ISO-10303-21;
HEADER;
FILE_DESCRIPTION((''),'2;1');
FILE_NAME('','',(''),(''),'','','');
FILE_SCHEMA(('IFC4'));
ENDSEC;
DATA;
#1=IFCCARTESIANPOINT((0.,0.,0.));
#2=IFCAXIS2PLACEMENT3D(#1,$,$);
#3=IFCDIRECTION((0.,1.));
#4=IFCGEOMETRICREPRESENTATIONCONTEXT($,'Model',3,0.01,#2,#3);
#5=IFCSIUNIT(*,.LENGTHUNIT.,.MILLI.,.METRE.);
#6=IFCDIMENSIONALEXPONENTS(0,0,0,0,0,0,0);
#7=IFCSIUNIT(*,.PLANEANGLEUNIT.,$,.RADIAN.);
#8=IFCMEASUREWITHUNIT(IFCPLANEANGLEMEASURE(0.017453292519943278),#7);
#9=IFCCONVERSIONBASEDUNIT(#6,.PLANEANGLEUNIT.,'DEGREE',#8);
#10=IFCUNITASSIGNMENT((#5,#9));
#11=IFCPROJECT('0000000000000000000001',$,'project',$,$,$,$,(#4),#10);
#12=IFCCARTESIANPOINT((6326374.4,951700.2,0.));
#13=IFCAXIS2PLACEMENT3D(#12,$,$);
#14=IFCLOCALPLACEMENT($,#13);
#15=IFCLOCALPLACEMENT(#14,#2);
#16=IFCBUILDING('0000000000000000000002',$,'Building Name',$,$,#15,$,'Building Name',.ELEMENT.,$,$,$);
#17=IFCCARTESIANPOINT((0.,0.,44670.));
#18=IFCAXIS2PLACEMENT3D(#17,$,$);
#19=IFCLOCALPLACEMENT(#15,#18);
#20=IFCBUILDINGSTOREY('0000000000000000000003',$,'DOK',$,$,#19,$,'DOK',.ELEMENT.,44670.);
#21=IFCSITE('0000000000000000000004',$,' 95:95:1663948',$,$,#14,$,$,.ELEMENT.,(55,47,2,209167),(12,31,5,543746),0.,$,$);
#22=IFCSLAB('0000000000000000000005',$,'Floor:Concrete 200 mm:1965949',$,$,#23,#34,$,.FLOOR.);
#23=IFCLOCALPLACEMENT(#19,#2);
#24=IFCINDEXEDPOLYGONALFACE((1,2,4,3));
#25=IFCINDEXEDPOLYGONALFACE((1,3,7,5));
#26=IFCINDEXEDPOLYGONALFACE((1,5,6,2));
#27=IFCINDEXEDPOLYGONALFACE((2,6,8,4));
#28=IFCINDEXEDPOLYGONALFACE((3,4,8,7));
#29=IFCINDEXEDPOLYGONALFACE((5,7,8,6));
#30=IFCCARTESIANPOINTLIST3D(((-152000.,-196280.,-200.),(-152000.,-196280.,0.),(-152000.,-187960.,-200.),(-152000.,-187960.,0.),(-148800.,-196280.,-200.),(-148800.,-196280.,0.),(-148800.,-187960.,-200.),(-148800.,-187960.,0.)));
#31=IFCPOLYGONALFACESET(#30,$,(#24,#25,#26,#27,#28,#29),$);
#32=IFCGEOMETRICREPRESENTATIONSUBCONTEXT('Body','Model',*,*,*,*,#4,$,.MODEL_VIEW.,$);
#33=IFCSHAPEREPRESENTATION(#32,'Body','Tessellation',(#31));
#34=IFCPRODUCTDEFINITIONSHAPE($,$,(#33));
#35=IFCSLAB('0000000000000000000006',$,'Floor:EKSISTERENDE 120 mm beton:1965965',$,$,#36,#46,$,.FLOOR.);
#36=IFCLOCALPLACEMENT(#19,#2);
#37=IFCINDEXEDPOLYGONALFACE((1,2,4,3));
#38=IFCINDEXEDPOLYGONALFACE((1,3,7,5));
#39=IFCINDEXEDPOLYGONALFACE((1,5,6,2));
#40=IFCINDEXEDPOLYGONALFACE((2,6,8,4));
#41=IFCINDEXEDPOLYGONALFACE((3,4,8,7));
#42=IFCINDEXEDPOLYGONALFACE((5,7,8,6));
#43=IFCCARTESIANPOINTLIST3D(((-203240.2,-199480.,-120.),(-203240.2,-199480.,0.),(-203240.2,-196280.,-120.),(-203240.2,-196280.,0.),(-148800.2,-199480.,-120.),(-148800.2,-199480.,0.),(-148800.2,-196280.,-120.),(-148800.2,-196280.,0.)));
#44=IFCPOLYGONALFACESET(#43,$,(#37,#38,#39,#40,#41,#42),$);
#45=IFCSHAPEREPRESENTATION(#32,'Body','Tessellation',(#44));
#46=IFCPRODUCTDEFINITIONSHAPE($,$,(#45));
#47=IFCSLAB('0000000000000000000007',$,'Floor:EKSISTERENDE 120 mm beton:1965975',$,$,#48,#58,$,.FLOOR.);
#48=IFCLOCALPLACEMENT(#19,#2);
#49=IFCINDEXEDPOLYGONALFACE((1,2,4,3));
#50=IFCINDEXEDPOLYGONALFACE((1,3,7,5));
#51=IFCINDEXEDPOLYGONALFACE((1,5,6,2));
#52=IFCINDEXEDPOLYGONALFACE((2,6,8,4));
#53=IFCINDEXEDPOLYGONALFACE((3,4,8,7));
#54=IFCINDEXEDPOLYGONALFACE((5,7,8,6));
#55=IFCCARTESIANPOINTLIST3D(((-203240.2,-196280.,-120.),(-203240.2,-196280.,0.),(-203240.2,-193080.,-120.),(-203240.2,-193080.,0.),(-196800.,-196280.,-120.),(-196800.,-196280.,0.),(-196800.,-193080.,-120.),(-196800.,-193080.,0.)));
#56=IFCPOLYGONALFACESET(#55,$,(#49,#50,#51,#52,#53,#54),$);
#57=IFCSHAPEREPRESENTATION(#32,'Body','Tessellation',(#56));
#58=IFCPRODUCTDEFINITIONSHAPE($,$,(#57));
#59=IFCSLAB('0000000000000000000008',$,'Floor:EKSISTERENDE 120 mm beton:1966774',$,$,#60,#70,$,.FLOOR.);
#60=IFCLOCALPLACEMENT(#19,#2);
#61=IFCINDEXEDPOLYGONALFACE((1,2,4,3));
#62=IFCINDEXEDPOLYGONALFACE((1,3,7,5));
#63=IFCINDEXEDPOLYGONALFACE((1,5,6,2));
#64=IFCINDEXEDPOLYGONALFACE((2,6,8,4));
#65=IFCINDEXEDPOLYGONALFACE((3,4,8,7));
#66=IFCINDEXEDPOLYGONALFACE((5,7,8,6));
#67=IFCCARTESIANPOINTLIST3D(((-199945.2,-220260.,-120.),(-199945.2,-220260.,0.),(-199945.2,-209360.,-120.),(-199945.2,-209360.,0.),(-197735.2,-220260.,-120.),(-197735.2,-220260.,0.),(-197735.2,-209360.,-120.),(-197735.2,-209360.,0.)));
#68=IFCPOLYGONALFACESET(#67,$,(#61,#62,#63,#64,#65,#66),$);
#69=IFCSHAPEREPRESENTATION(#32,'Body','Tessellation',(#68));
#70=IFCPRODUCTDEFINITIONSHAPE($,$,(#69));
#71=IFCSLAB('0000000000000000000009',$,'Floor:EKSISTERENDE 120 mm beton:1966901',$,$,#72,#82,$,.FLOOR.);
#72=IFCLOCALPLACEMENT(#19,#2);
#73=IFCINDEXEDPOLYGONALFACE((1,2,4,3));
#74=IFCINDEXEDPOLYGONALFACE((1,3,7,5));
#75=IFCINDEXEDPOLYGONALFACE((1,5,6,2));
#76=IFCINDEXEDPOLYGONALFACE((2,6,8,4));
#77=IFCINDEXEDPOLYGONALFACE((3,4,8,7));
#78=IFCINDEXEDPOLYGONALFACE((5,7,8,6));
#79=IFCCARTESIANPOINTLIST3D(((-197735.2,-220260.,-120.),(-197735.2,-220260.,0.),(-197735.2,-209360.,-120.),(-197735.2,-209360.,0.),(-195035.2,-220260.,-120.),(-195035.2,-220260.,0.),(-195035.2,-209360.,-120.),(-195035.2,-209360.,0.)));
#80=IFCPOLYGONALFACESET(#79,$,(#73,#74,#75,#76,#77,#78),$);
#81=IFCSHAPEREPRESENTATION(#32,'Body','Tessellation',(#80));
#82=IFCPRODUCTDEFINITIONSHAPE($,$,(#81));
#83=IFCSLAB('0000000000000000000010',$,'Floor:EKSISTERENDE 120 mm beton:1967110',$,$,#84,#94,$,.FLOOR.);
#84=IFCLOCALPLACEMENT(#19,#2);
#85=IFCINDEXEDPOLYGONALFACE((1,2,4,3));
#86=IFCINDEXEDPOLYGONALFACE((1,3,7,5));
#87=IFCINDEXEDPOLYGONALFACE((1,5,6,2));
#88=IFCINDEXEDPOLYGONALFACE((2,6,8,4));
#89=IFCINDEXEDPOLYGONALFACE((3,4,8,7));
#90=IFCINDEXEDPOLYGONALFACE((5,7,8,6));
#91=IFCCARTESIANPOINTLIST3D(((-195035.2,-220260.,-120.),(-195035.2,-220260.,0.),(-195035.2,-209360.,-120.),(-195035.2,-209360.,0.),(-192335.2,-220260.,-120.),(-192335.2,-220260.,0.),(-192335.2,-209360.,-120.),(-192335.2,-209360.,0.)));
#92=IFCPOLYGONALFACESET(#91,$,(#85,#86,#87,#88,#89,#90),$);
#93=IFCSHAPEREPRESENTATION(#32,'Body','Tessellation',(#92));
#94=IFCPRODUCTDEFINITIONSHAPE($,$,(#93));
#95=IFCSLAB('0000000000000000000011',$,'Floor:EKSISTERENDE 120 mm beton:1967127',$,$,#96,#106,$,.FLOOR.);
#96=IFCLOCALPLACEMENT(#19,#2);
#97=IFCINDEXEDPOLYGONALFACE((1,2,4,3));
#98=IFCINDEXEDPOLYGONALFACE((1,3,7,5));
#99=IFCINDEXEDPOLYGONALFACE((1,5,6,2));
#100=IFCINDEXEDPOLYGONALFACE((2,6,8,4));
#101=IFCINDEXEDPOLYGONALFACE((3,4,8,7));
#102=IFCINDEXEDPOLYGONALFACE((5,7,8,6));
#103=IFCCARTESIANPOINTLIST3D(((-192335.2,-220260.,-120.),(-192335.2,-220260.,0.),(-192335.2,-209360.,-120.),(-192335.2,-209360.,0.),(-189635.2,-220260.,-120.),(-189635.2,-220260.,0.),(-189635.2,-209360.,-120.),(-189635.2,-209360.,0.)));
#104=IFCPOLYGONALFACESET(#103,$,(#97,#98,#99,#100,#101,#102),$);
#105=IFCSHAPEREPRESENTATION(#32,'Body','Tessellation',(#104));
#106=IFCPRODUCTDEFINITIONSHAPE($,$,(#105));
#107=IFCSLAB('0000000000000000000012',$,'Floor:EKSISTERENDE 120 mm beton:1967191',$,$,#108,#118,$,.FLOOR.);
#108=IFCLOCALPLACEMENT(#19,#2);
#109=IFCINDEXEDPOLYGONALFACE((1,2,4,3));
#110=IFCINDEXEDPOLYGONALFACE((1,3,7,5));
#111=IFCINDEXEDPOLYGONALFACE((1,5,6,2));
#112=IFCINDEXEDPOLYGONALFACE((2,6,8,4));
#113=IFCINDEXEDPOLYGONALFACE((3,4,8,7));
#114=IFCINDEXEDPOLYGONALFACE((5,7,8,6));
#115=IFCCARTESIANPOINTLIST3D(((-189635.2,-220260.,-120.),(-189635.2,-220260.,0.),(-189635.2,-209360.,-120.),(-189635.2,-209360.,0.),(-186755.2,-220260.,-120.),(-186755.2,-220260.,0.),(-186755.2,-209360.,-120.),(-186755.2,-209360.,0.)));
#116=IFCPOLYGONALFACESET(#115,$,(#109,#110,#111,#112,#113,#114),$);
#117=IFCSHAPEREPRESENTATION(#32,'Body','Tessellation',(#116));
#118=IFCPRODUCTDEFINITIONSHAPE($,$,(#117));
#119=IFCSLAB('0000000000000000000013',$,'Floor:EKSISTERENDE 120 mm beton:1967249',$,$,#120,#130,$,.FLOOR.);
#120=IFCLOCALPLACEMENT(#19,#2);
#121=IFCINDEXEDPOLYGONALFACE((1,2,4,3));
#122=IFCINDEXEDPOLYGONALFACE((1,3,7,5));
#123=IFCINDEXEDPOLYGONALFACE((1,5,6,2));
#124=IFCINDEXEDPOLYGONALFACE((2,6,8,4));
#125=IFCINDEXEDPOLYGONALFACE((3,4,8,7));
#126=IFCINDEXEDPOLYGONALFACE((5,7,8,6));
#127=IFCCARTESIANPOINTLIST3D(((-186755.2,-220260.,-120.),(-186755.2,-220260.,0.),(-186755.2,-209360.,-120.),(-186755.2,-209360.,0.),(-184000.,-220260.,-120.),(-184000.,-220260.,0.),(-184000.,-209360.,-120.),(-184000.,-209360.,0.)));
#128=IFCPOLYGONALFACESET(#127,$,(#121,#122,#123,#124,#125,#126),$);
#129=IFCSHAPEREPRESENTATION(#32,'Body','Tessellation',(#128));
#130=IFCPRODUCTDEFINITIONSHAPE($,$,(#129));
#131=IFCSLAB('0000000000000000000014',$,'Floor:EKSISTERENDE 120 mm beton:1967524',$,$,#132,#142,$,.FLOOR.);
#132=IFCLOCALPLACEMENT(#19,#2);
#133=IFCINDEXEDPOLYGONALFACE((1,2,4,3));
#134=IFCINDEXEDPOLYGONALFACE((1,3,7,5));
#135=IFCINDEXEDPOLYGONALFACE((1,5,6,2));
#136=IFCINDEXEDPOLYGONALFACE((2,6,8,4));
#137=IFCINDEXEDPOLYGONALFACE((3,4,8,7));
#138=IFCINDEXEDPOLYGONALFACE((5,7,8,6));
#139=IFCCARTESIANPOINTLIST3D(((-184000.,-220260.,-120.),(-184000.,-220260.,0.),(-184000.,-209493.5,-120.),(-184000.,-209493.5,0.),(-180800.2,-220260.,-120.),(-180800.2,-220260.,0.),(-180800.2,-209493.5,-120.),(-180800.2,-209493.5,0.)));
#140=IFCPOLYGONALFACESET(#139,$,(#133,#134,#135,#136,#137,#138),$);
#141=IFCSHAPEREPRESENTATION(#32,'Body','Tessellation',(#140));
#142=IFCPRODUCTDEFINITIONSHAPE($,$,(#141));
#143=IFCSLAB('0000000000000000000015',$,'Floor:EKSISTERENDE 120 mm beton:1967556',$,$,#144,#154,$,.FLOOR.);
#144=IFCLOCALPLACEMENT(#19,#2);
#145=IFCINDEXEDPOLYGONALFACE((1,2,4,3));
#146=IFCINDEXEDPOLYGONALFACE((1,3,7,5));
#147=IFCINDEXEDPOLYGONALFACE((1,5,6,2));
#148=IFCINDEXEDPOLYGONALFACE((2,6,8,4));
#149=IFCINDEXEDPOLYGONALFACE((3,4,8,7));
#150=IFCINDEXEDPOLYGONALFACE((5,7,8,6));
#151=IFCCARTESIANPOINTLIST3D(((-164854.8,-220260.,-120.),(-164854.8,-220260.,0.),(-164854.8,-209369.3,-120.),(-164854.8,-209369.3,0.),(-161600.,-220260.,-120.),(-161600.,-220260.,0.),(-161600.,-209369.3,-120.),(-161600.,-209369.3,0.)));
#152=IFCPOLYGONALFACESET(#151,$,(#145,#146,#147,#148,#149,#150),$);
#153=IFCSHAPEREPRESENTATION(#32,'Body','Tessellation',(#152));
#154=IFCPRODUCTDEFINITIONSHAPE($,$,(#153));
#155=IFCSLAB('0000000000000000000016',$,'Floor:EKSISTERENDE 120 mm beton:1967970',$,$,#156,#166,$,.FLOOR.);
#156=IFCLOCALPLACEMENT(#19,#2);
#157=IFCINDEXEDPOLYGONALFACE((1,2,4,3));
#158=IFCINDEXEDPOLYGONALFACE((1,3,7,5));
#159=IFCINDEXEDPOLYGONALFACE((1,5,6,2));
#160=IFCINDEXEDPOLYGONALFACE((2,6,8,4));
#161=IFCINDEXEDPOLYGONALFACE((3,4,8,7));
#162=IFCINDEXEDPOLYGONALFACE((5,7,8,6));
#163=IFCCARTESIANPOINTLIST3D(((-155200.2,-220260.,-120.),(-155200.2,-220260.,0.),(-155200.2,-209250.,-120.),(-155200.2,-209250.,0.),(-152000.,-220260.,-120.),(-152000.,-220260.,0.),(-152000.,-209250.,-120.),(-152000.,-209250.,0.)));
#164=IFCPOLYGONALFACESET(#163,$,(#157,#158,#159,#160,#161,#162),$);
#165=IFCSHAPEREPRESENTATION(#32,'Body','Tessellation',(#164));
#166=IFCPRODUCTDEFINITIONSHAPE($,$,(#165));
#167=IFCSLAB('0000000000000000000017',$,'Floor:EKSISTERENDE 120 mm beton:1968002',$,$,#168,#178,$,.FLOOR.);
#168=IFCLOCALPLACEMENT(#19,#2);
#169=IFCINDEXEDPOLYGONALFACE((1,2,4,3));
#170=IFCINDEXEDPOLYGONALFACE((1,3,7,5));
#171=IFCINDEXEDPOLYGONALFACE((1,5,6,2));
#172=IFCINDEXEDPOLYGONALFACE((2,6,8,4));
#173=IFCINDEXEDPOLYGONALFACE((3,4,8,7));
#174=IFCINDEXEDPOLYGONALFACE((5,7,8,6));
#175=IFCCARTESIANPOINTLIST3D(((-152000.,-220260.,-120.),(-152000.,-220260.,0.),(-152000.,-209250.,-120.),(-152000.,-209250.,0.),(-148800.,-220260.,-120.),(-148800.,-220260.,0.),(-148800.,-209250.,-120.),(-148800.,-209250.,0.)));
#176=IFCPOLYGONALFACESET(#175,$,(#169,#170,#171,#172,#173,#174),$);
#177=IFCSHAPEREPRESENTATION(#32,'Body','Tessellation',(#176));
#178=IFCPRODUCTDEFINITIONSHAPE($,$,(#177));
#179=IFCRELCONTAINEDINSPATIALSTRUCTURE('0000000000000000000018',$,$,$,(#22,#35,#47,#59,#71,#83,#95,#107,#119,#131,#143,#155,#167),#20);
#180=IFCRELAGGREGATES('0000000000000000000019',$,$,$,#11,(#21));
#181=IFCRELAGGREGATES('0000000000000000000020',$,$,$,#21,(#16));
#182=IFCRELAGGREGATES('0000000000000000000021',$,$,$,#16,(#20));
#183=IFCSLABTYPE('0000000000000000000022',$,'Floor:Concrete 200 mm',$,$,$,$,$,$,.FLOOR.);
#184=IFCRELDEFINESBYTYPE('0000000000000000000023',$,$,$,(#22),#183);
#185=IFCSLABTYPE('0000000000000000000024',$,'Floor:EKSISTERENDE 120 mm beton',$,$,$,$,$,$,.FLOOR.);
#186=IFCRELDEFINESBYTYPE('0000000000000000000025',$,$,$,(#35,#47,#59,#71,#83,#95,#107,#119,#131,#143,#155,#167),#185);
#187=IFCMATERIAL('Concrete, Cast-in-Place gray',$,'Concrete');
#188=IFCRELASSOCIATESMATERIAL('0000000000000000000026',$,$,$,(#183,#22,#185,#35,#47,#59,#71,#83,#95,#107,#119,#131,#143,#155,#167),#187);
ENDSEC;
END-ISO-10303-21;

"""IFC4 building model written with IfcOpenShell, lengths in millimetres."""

from ifc_helpers import new_model, entity, si_unit, converted_unit, direction, frame, origin, place, context, subcontext, project, spatial, indexed_curve, outline, extrude, material, type_object, element, save


model = new_model("IFC4")

# Units and contexts
model_context = context("Model", 3, precision=0.01, world=origin(), true_north=direction((0.0, 1.0)))
body_context = subcontext(model_context, "Body", "Model", "MODEL_VIEW")
ifc_project = project(units=[si_unit("LENGTHUNIT", "METRE", prefix="MILLI"), converted_unit("PLANEANGLEUNIT", "DEGREE", entity("IfcPlaneAngleMeasure", 0.017453292519943278), si_unit("PLANEANGLEUNIT", "RADIAN"), dimensions=[0, 0, 0, 0, 0, 0, 0])], contexts=[model_context])

# Site, building, storey
site_placement = place(None, frame((6326374.4, 951700.2, 0.0)))
site = spatial("IfcSite", under=ifc_project, at=site_placement, Name=" 95:95:1663948", CompositionType="ELEMENT", RefLatitude=(55, 47, 2, 209167), RefLongitude=(12, 31, 5, 543746), RefElevation=0.0)
building_placement = place(site_placement, origin())
building = spatial("IfcBuilding", under=site, at=building_placement, Name="Building Name", LongName="Building Name", CompositionType="ELEMENT")
storey_placement = place(building_placement, frame((0.0, 0.0, 44670.0)))
storey = spatial("IfcBuildingStorey", under=building, at=storey_placement, Name="DOK", LongName="DOK", CompositionType="ELEMENT", Elevation=44670.0)

# Slabs
ifc_material = material(Name="Concrete, Cast-in-Place gray", Category="Concrete")
slab_type_1 = type_object("IfcSlabType", Name="Floor:Concrete 200 mm", PredefinedType="FLOOR", material=ifc_material)
slab_1_placement = place(storey_placement, origin())
element("IfcSlab", 1, at=slab_1_placement, inside=storey, type_object=slab_type_1, material=ifc_material, Name="Floor:Concrete 200 mm:1965949", PredefinedType="FLOOR", context=body_context, shape_type="SweptSolid", body=[
    extrude(outline(indexed_curve([(-4160.0, -1600.0), (4160.0, -1600.0), (4160.0, 1600.0), (-4160.0, 1600.0), (-4160.0, -1600.0)], self_intersect=False)), frame((-150400.0, -192120.0, 0.0), z_axis=(0.0, 0.0, -1.0), x_axis=(0.0, 1.0, 0.0)), (0.0, 0.0, 1.0), 200.0),
])
slab_type_2 = type_object("IfcSlabType", Name="Floor:EKSISTERENDE 120 mm beton", PredefinedType="FLOOR", material=ifc_material)
slab_2_placement = place(storey_placement, origin())
element("IfcSlab", 2, at=slab_2_placement, inside=storey, type_object=slab_type_2, material=ifc_material, Name="Floor:EKSISTERENDE 120 mm beton:1965965", PredefinedType="FLOOR", context=body_context, shape_type="SweptSolid", body=[
    extrude(outline(indexed_curve([(-1600.0, -27220.0), (1600.0, -27220.0), (1600.0, 27220.0), (-1600.0, 27220.0), (-1600.0, -27220.0)], self_intersect=False)), frame((-176020.2, -197880.0, 0.0), z_axis=(0.0, 0.0, -1.0), x_axis=(0.0, 1.0, 0.0)), (0.0, 0.0, 1.0), 120.0),
])
slab_3_placement = place(storey_placement, origin())
element("IfcSlab", 3, at=slab_3_placement, inside=storey, type_object=slab_type_2, material=ifc_material, Name="Floor:EKSISTERENDE 120 mm beton:1965975", PredefinedType="FLOOR", context=body_context, shape_type="SweptSolid", body=[
    extrude(outline(indexed_curve([(-1600.0, -3220.1), (1600.0, -3220.1), (1600.0, 3220.1), (-1600.0, 3220.1), (-1600.0, -3220.1)], self_intersect=False)), frame((-200020.1, -194680.0, 0.0), z_axis=(0.0, 0.0, -1.0), x_axis=(0.0, 1.0, 0.0)), (0.0, 0.0, 1.0), 120.0),
])
slab_4_placement = place(storey_placement, origin())
element("IfcSlab", 4, at=slab_4_placement, inside=storey, type_object=slab_type_2, material=ifc_material, Name="Floor:EKSISTERENDE 120 mm beton:1966774", PredefinedType="FLOOR", context=body_context, shape_type="SweptSolid", body=[
    extrude(outline(indexed_curve([(-5450.0, -1105.0), (5450.0, -1105.0), (5450.0, 1105.0), (-5450.0, 1105.0), (-5450.0, -1105.0)], self_intersect=False)), frame((-198840.2, -214810.0, 0.0), z_axis=(0.0, 0.0, -1.0), x_axis=(0.0, 1.0, 0.0)), (0.0, 0.0, 1.0), 120.0),
])
slab_5_placement = place(storey_placement, origin())
element("IfcSlab", 5, at=slab_5_placement, inside=storey, type_object=slab_type_2, material=ifc_material, Name="Floor:EKSISTERENDE 120 mm beton:1966901", PredefinedType="FLOOR", context=body_context, shape_type="SweptSolid", body=[
    extrude(outline(indexed_curve([(-5450.0, -1350.0), (5450.0, -1350.0), (5450.0, 1350.0), (-5450.0, 1350.0), (-5450.0, -1350.0)], self_intersect=False)), frame((-196385.2, -214810.0, 0.0), z_axis=(0.0, 0.0, -1.0), x_axis=(0.0, 1.0, 0.0)), (0.0, 0.0, 1.0), 120.0),
])
slab_6_placement = place(storey_placement, origin())
element("IfcSlab", 6, at=slab_6_placement, inside=storey, type_object=slab_type_2, material=ifc_material, Name="Floor:EKSISTERENDE 120 mm beton:1967110", PredefinedType="FLOOR", context=body_context, shape_type="SweptSolid", body=[
    extrude(outline(indexed_curve([(-5450.0, -1350.0), (5450.0, -1350.0), (5450.0, 1350.0), (-5450.0, 1350.0), (-5450.0, -1350.0)], self_intersect=False)), frame((-193685.2, -214810.0, 0.0), z_axis=(0.0, 0.0, -1.0), x_axis=(0.0, 1.0, 0.0)), (0.0, 0.0, 1.0), 120.0),
])
slab_7_placement = place(storey_placement, origin())
element("IfcSlab", 7, at=slab_7_placement, inside=storey, type_object=slab_type_2, material=ifc_material, Name="Floor:EKSISTERENDE 120 mm beton:1967127", PredefinedType="FLOOR", context=body_context, shape_type="SweptSolid", body=[
    extrude(outline(indexed_curve([(-5450.0, -1350.0), (5450.0, -1350.0), (5450.0, 1350.0), (-5450.0, 1350.0), (-5450.0, -1350.0)], self_intersect=False)), frame((-190985.2, -214810.0, 0.0), z_axis=(0.0, 0.0, -1.0), x_axis=(0.0, 1.0, 0.0)), (0.0, 0.0, 1.0), 120.0),
])
slab_8_placement = place(storey_placement, origin())
element("IfcSlab", 8, at=slab_8_placement, inside=storey, type_object=slab_type_2, material=ifc_material, Name="Floor:EKSISTERENDE 120 mm beton:1967191", PredefinedType="FLOOR", context=body_context, shape_type="SweptSolid", body=[
    extrude(outline(indexed_curve([(-5450.0, -1440.0), (5450.0, -1440.0), (5450.0, 1440.0), (-5450.0, 1440.0), (-5450.0, -1440.0)], self_intersect=False)), frame((-188195.2, -214810.0, 0.0), z_axis=(0.0, 0.0, -1.0), x_axis=(0.0, 1.0, 0.0)), (0.0, 0.0, 1.0), 120.0),
])
slab_9_placement = place(storey_placement, origin())
element("IfcSlab", 9, at=slab_9_placement, inside=storey, type_object=slab_type_2, material=ifc_material, Name="Floor:EKSISTERENDE 120 mm beton:1967249", PredefinedType="FLOOR", context=body_context, shape_type="SweptSolid", body=[
    extrude(outline(indexed_curve([(-5450.0, -1377.6), (5450.0, -1377.6), (5450.0, 1377.6), (-5450.0, 1377.6), (-5450.0, -1377.6)], self_intersect=False)), frame((-185377.6, -214810.0, 0.0), z_axis=(0.0, 0.0, -1.0), x_axis=(0.0, 1.0, 0.0)), (0.0, 0.0, 1.0), 120.0),
])
slab_10_placement = place(storey_placement, origin())
element("IfcSlab", 10, at=slab_10_placement, inside=storey, type_object=slab_type_2, material=ifc_material, Name="Floor:EKSISTERENDE 120 mm beton:1967524", PredefinedType="FLOOR", context=body_context, shape_type="SweptSolid", body=[
    extrude(outline(indexed_curve([(-5383.3, -1599.9), (5383.3, -1599.9), (5383.3, 1599.9), (-5383.3, 1599.9), (-5383.3, -1599.9)], self_intersect=False)), frame((-182400.1, -214876.7, 0.0), z_axis=(0.0, 0.0, -1.0), x_axis=(0.0, 1.0, 0.0)), (0.0, 0.0, 1.0), 120.0),
])
slab_11_placement = place(storey_placement, origin())
element("IfcSlab", 11, at=slab_11_placement, inside=storey, type_object=slab_type_2, material=ifc_material, Name="Floor:EKSISTERENDE 120 mm beton:1967556", PredefinedType="FLOOR", context=body_context, shape_type="SweptSolid", body=[
    extrude(outline(indexed_curve([(-5445.3, -1627.4), (5445.3, -1627.4), (5445.3, 1627.4), (-5445.3, 1627.4), (-5445.3, -1627.4)], self_intersect=False)), frame((-163227.4, -214814.7, 0.0), z_axis=(0.0, 0.0, -1.0), x_axis=(0.0, 1.0, 0.0)), (0.0, 0.0, 1.0), 120.0),
])
slab_12_placement = place(storey_placement, origin())
element("IfcSlab", 12, at=slab_12_placement, inside=storey, type_object=slab_type_2, material=ifc_material, Name="Floor:EKSISTERENDE 120 mm beton:1967970", PredefinedType="FLOOR", context=body_context, shape_type="SweptSolid", body=[
    extrude(outline(indexed_curve([(-5505.0, -1600.1), (5505.0, -1600.1), (5505.0, 1600.1), (-5505.0, 1600.1), (-5505.0, -1600.1)], self_intersect=False)), frame((-153600.1, -214755.0, 0.0), z_axis=(0.0, 0.0, -1.0), x_axis=(0.0, 1.0, 0.0)), (0.0, 0.0, 1.0), 120.0),
])
slab_13_placement = place(storey_placement, origin())
element("IfcSlab", 13, at=slab_13_placement, inside=storey, type_object=slab_type_2, material=ifc_material, Name="Floor:EKSISTERENDE 120 mm beton:1968002", PredefinedType="FLOOR", context=body_context, shape_type="SweptSolid", body=[
    extrude(outline(indexed_curve([(-5505.0, -1600.0), (5505.0, -1600.0), (5505.0, 1600.0), (-5505.0, 1600.0), (-5505.0, -1600.0)], self_intersect=False)), frame((-150400.0, -214755.0, 0.0), z_axis=(0.0, 0.0, -1.0), x_axis=(0.0, 1.0, 0.0)), (0.0, 0.0, 1.0), 120.0),
])

save(model, "model.ifc")
